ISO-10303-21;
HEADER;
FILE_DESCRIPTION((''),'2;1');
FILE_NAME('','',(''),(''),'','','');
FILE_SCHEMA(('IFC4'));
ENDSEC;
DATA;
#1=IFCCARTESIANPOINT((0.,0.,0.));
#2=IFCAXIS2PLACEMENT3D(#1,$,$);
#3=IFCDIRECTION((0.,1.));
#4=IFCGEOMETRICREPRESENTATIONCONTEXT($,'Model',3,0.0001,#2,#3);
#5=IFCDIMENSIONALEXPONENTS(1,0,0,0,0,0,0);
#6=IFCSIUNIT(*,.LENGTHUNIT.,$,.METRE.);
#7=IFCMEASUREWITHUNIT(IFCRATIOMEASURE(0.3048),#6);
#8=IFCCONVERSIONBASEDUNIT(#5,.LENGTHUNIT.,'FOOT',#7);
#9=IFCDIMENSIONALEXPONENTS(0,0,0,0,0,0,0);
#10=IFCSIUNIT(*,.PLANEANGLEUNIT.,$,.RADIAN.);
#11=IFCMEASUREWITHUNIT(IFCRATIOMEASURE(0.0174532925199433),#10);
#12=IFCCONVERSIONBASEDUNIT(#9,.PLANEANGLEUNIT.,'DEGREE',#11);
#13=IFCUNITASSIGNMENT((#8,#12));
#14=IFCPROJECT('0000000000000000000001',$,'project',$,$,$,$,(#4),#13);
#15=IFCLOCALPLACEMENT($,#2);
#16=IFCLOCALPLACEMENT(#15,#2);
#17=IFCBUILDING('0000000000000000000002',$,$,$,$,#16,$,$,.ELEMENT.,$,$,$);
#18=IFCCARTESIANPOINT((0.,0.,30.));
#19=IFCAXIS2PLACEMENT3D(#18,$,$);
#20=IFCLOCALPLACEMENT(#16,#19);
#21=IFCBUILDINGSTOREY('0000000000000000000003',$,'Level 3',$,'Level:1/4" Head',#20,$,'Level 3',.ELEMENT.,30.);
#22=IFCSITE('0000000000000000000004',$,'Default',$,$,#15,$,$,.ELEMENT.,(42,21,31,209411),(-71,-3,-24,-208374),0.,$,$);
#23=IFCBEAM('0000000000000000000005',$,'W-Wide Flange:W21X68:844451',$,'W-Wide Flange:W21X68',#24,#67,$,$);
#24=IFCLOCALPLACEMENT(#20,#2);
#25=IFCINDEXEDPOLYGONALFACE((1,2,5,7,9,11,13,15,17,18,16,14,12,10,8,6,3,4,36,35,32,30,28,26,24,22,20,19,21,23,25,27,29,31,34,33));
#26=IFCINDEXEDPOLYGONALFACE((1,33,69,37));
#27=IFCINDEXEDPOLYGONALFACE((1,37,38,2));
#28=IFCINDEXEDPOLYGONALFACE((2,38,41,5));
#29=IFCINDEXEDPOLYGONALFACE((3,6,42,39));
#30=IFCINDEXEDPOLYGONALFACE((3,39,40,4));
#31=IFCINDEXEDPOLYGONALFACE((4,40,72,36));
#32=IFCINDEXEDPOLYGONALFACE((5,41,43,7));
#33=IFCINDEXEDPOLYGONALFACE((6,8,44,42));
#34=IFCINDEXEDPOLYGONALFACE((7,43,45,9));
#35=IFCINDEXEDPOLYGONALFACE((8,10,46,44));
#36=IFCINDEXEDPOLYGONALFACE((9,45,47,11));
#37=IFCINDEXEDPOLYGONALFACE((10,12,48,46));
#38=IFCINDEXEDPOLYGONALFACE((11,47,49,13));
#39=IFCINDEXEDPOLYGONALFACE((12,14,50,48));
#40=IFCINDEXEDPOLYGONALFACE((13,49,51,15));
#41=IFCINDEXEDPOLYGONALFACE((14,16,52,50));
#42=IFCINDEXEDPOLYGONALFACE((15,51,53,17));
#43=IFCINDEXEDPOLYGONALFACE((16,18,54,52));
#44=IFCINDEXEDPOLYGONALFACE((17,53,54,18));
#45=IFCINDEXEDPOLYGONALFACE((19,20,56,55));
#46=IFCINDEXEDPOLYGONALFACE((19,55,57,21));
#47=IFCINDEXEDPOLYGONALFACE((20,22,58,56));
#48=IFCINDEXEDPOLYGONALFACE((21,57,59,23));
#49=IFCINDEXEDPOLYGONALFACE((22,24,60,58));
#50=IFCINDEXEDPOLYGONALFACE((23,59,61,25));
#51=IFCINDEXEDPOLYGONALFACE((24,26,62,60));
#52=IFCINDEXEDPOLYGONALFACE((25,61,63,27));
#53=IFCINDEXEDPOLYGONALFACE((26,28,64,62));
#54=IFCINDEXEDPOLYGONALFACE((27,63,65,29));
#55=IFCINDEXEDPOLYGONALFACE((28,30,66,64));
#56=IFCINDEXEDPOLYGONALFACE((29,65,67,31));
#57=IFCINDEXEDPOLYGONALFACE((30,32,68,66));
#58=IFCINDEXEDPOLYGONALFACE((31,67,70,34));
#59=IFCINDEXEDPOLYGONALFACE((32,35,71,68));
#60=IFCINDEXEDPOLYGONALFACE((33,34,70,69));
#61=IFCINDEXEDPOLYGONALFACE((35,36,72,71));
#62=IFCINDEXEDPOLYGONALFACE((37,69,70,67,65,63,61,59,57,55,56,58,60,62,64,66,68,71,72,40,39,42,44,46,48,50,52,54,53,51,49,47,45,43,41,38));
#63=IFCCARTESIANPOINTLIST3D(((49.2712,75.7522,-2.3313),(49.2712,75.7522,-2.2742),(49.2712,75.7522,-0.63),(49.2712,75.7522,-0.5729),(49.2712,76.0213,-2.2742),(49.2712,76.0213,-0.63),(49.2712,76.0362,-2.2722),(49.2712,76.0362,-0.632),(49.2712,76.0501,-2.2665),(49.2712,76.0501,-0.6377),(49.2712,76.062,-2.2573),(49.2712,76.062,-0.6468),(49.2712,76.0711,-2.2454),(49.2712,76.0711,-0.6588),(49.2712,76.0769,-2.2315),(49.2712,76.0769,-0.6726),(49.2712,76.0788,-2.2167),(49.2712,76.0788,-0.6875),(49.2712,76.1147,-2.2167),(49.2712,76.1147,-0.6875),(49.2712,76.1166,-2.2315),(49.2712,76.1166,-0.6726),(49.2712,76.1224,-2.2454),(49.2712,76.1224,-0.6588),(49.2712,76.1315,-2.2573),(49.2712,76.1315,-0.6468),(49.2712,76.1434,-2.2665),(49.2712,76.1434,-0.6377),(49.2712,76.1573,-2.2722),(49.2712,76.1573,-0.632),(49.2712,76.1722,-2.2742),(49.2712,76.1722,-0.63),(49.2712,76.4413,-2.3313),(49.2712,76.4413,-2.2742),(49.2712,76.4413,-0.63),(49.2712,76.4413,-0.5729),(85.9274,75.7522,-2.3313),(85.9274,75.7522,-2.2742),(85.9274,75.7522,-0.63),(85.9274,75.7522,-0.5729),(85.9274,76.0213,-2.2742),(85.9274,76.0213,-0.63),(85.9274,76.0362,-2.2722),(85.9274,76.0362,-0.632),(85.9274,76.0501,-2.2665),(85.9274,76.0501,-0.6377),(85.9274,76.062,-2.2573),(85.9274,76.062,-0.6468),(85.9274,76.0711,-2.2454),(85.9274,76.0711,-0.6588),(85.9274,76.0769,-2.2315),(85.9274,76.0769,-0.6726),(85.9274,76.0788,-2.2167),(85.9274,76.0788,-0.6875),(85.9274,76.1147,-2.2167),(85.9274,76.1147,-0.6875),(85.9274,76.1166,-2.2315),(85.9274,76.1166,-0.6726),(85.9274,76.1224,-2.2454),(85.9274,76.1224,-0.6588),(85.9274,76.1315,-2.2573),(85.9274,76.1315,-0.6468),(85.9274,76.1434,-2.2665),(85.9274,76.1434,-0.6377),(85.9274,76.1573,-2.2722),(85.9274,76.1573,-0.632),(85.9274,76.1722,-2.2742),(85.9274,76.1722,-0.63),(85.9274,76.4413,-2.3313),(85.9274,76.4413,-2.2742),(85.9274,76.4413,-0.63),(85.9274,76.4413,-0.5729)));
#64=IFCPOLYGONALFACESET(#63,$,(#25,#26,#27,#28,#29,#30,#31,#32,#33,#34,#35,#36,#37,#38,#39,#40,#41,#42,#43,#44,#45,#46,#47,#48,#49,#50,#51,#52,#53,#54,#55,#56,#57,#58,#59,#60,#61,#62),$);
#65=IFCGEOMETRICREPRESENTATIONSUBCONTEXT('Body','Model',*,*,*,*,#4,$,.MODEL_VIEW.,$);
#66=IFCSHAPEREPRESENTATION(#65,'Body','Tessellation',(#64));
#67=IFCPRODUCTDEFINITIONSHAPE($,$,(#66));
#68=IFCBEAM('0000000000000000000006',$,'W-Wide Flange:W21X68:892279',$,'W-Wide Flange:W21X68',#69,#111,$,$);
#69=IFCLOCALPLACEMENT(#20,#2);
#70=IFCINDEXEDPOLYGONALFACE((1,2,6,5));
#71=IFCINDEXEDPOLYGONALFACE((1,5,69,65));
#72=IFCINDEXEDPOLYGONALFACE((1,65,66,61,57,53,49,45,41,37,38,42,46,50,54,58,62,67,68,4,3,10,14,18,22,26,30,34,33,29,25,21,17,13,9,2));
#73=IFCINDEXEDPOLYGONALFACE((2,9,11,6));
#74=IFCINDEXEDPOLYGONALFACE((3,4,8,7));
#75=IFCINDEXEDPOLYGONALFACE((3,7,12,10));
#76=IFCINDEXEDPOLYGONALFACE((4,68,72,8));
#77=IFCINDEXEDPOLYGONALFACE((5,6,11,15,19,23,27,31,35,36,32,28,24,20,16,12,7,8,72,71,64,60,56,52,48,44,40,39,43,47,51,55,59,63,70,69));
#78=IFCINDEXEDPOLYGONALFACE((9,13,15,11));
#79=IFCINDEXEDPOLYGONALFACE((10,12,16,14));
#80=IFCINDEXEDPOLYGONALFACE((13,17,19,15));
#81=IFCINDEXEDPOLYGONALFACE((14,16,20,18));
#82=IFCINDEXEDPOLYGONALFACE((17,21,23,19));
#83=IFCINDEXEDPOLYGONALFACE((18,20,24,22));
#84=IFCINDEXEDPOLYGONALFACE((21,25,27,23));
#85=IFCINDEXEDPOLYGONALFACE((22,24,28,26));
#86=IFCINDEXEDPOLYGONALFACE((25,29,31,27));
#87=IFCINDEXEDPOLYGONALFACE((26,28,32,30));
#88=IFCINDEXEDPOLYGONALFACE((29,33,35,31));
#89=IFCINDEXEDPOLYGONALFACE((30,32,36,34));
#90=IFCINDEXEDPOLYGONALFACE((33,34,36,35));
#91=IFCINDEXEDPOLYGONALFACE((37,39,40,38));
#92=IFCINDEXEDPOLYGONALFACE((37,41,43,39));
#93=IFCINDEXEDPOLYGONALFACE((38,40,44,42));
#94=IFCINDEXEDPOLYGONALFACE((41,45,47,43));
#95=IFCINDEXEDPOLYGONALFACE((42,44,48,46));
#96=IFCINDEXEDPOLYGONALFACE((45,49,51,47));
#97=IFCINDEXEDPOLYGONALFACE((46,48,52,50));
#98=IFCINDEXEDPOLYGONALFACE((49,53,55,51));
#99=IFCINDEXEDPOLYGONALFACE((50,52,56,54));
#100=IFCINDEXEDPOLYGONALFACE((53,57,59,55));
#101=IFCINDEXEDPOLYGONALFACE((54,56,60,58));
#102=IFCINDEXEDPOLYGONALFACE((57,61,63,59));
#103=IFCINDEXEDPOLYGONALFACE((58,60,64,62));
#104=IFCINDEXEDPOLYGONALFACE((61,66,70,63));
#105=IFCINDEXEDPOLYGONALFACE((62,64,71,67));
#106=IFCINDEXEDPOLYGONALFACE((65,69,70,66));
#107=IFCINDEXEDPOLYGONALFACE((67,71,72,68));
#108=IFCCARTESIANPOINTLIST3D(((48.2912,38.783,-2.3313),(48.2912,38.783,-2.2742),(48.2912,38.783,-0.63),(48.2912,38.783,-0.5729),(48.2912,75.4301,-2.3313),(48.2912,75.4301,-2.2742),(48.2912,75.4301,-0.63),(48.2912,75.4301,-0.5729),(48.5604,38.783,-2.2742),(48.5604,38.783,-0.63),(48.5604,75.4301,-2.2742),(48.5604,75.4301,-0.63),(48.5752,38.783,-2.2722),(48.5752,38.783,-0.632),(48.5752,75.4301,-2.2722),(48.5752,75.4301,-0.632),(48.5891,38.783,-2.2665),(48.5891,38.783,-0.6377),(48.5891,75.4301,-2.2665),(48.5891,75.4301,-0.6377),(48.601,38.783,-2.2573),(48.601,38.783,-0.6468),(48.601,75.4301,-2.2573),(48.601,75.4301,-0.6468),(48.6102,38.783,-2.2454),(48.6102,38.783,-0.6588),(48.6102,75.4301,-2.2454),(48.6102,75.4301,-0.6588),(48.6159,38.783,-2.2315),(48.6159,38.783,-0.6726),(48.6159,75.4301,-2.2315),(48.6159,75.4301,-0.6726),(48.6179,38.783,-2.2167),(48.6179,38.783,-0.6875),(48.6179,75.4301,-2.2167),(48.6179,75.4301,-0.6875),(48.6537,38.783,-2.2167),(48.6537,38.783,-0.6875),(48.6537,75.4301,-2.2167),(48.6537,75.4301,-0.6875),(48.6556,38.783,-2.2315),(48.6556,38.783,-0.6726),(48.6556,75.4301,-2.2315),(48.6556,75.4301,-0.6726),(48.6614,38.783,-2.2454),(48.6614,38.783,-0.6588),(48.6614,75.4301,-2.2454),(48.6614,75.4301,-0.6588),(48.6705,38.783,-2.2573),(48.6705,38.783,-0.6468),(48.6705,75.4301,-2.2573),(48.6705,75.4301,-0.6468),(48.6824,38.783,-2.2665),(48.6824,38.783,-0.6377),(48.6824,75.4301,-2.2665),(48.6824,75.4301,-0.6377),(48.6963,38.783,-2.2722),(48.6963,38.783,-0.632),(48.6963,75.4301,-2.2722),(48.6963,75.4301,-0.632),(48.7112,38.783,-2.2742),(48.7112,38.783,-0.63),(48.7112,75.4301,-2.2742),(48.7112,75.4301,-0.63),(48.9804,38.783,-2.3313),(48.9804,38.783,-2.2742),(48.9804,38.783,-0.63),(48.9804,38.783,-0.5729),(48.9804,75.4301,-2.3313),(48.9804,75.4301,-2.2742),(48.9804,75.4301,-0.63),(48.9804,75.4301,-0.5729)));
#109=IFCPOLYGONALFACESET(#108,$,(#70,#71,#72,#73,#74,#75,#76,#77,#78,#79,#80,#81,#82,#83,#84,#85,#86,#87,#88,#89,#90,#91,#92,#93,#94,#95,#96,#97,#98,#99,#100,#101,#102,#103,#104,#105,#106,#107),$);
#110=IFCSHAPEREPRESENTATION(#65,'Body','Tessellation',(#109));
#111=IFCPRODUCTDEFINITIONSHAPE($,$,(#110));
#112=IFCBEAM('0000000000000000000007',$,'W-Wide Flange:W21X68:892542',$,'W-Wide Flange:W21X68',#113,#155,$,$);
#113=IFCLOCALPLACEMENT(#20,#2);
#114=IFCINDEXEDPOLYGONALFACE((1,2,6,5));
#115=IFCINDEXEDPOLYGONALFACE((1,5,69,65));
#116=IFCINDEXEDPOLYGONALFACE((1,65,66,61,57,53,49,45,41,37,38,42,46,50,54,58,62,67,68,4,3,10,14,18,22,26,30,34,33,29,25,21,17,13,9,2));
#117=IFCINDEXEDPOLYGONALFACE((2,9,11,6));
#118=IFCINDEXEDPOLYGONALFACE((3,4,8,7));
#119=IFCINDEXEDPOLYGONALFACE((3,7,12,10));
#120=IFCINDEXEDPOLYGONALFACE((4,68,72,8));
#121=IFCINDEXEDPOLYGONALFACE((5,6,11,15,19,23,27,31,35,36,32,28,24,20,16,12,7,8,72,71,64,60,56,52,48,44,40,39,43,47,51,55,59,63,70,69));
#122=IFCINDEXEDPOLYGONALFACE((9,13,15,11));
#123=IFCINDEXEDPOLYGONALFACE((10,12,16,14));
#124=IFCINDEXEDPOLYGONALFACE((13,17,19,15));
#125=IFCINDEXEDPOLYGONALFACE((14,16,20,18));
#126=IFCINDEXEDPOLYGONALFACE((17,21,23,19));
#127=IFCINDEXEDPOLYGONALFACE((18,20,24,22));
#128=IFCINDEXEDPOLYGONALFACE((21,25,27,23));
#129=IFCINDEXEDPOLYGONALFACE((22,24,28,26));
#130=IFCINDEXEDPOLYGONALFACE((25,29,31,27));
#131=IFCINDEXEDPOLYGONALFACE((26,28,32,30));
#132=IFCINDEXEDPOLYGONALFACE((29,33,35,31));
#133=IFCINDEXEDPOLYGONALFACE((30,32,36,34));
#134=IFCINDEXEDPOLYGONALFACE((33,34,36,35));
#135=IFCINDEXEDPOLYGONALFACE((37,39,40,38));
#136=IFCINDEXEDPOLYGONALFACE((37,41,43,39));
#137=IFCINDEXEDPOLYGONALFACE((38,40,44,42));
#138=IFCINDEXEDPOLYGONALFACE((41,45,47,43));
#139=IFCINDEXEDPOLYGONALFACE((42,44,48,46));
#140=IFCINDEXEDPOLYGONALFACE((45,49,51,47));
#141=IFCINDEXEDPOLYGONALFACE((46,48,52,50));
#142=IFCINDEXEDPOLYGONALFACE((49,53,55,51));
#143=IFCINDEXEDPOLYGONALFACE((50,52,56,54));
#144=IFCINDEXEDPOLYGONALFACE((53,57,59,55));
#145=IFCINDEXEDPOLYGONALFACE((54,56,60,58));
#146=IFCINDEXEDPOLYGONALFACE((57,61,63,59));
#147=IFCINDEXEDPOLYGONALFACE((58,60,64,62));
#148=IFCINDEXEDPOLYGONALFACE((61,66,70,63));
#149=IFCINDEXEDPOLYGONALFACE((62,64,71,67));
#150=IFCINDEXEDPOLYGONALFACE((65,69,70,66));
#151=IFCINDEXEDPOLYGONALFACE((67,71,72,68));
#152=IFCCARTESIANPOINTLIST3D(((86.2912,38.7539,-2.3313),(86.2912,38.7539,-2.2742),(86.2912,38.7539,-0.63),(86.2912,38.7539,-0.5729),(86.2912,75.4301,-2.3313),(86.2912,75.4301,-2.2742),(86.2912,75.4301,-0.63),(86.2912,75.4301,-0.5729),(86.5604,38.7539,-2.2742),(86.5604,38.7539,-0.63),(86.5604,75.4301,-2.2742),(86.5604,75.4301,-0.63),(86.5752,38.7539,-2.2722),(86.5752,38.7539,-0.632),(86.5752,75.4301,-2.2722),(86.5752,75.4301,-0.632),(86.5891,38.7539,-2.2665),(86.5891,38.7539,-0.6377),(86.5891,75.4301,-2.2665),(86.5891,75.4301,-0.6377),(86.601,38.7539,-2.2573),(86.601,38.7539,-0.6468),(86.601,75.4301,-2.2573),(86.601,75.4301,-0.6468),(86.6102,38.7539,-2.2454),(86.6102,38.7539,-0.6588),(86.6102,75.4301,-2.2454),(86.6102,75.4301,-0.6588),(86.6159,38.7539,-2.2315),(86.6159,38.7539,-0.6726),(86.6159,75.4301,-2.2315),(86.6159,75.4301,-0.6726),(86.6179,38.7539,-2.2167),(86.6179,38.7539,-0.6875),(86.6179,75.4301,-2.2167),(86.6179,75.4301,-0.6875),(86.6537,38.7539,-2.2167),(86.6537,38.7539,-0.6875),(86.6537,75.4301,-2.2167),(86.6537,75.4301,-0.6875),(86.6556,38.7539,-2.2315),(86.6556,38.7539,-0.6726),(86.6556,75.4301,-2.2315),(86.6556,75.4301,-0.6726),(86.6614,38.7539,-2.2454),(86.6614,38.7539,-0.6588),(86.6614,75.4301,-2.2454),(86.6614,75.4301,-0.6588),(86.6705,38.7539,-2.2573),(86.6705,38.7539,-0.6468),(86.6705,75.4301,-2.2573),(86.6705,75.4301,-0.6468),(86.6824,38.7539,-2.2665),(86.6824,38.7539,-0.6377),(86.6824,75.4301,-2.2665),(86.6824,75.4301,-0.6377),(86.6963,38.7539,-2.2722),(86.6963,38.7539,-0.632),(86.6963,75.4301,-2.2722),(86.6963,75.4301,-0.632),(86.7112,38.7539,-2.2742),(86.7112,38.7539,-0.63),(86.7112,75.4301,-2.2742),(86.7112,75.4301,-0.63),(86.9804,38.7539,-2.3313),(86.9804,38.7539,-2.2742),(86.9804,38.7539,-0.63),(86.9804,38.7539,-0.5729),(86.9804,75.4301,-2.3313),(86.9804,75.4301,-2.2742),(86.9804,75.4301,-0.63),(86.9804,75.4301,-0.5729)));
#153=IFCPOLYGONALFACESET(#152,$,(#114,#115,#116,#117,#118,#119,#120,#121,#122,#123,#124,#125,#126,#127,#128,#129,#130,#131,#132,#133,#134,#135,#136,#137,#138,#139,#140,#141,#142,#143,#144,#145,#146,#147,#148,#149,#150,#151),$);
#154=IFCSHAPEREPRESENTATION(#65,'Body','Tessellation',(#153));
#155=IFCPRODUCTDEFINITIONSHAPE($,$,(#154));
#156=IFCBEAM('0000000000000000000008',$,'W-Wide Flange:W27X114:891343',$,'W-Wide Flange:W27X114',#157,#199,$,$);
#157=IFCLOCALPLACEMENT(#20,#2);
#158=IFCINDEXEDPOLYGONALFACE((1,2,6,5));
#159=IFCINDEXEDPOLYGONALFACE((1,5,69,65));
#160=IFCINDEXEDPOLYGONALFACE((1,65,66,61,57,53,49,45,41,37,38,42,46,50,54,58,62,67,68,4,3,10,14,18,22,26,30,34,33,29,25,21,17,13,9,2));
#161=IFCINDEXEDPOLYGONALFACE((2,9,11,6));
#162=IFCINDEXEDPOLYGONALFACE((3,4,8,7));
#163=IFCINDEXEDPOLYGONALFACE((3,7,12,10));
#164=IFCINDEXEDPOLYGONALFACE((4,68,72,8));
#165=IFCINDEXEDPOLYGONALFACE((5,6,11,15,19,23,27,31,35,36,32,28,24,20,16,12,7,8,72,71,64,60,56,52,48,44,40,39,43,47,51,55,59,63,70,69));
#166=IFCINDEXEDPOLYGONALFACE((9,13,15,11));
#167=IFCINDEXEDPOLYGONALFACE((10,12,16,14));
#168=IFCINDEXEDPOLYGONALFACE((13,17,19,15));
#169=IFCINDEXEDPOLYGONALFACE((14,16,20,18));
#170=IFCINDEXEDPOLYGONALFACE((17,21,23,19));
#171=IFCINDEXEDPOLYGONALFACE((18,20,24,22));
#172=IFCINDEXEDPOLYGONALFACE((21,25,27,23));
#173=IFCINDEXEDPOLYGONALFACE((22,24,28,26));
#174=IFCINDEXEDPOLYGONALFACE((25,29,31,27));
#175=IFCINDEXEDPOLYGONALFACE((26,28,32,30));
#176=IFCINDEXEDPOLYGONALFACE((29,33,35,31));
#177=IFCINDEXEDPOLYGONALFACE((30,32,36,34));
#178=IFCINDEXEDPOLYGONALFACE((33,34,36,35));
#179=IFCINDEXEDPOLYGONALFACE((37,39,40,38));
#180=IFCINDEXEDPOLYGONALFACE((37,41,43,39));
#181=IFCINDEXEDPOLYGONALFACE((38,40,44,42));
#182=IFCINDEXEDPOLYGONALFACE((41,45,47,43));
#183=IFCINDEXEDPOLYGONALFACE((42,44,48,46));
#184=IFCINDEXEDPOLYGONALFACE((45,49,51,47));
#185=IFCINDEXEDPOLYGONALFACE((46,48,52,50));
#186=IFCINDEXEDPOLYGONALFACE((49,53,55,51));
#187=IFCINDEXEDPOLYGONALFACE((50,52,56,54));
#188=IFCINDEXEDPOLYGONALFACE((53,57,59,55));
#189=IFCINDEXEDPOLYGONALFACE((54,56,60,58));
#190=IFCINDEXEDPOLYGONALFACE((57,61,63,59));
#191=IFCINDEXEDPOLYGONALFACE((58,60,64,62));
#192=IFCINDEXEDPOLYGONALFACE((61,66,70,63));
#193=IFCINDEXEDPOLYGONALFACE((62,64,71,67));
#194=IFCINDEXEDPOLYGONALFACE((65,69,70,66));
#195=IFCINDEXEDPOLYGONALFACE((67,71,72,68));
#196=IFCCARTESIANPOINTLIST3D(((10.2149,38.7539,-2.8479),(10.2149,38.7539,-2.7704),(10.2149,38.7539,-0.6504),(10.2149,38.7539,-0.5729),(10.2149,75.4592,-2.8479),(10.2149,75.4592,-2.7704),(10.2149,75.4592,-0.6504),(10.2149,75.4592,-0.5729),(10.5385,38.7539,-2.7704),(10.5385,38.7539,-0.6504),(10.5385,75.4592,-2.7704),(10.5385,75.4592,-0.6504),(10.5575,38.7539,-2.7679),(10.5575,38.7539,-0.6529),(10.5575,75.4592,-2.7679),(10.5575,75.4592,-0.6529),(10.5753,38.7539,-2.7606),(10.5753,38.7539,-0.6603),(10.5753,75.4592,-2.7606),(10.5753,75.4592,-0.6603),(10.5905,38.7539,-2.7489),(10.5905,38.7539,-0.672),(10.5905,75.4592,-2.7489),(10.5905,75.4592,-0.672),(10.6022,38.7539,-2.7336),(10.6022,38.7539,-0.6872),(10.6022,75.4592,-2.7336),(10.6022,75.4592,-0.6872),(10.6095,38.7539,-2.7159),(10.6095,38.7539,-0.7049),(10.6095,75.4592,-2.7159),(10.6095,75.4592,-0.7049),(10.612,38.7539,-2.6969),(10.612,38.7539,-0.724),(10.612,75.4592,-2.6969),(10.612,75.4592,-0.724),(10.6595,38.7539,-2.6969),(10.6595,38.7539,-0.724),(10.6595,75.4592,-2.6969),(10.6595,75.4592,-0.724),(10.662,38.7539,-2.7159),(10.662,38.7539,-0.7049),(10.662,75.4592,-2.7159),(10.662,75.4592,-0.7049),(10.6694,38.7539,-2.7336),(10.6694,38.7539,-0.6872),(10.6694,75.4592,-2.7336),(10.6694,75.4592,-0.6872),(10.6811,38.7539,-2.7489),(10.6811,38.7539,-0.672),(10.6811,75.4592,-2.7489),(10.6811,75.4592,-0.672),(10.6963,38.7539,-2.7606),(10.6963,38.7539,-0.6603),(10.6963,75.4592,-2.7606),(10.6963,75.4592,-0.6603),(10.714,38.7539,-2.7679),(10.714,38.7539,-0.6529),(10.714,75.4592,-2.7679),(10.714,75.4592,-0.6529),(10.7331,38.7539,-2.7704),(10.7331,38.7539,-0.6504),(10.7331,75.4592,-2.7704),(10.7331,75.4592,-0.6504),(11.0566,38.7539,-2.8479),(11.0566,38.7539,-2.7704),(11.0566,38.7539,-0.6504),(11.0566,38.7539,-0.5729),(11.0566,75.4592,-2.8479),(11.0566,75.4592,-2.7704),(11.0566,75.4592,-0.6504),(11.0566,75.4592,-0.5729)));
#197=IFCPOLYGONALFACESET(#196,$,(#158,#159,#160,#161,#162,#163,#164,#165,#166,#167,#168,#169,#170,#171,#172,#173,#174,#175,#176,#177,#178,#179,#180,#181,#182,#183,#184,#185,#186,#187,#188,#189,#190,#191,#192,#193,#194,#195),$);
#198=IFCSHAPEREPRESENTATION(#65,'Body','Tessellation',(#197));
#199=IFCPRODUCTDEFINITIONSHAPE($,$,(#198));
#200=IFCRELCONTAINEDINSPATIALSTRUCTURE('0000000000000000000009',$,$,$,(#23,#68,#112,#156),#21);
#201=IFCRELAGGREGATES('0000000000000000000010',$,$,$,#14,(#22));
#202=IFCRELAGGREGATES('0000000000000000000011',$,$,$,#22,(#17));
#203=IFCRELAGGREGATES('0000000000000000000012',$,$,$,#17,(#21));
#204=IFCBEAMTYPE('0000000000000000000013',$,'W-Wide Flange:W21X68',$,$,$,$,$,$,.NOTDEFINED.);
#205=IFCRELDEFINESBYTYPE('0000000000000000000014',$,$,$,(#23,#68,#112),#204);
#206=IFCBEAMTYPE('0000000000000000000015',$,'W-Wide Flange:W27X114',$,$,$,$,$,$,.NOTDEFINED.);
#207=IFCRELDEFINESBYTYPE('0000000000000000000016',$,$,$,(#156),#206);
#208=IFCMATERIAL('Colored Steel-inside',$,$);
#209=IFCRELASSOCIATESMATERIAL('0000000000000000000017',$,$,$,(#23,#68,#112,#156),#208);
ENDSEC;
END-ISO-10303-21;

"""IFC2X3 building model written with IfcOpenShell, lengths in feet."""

from ifc_helpers import new_model, entity, si_unit, converted_unit, direction, frame, frame_2d, origin, place, context, subcontext, project, spatial, i_section, extrude, material, type_object, element, save


model = new_model("IFC2X3")

# Units and contexts
model_context = context("Model", 3, precision=0.0001, world=origin(), true_north=direction((0.0, 1.0)))
body_context = subcontext(model_context, "Body", "Model", "MODEL_VIEW")
ifc_project = project(units=[converted_unit("LENGTHUNIT", "FOOT", entity("IfcRatioMeasure", 0.3048), si_unit("LENGTHUNIT", "METRE"), dimensions=[1, 0, 0, 0, 0, 0, 0]), converted_unit("PLANEANGLEUNIT", "DEGREE", entity("IfcRatioMeasure", 0.0174532925199433), si_unit("PLANEANGLEUNIT", "RADIAN"), dimensions=[0, 0, 0, 0, 0, 0, 0])], contexts=[model_context])

# Site, building, storey
site_placement = place(None, origin())
site = spatial("IfcSite", under=ifc_project, at=site_placement, Name="Default", CompositionType="ELEMENT", RefLatitude=(42, 21, 31, 209411), RefLongitude=(-71, -3, -24, -208374), RefElevation=0.0)
building_placement = place(site_placement, origin())
building = spatial("IfcBuilding", under=site, at=building_placement, CompositionType="ELEMENT")
storey_placement = place(building_placement, frame((0.0, 0.0, 30.0)))
storey = spatial("IfcBuildingStorey", under=building, at=storey_placement, Name="Level 3", ObjectType="Level:1/4\" Head", LongName="Level 3", CompositionType="ELEMENT", Elevation=30.0)

# Beams
ifc_material_1 = material(Name="Colored Steel-inside")
beam_type_1 = type_object("IfcBeamType", Name="W-Wide Flange:W21X68", PredefinedType="NOTDEFINED")
beam_1_placement = place(storey_placement, frame((86.6554, 76.0968, 0.0), z_axis=(0.0, 0.0, 1.0), x_axis=(-1.0, 0.0, 0.0)))
element("IfcBeam", 1, at=beam_1_placement, inside=storey, type_object=beam_type_1, material=ifc_material_1, Name="W-Wide Flange:W21X68:844451", ObjectType="W-Wide Flange:W21X68", context=body_context, shape_type="SweptSolid", body=[
    extrude(i_section(OverallWidth=0.6892, OverallDepth=1.7583, WebThickness=0.0358, FlangeThickness=0.0571, FilletRadius=0.0575, at=frame_2d((0.0, 0.0), x_axis=(0.0, 1.0))), frame((0.7279, 0.0, -1.4521), z_axis=(1.0, 0.0, 0.0), x_axis=(0.0, 0.0, -1.0)), (0.0, 0.0, 1.0), 36.6562),
])
beam_2_placement = place(storey_placement, frame((48.6358, 76.0968, 0.0), z_axis=(0.0, 0.0, 1.0), x_axis=(0.0, -1.0, 0.0)))
element("IfcBeam", 2, at=beam_2_placement, inside=storey, type_object=beam_type_1, material=ifc_material_1, Name="W-Wide Flange:W21X68:892279", ObjectType="W-Wide Flange:W21X68", context=body_context, shape_type="SweptSolid", body=[
    extrude(i_section(OverallWidth=0.6892, OverallDepth=1.7583, WebThickness=0.0358, FlangeThickness=0.0571, FilletRadius=0.0575, at=frame_2d((0.0, 0.0), x_axis=(0.0, 1.0))), frame((0.6667, 0.0, -1.4521), z_axis=(1.0, 0.0, 0.0), x_axis=(0.0, 0.0, -1.0)), (0.0, 0.0, 1.0), 36.6471),
])
beam_3_placement = place(storey_placement, frame((86.6358, 76.0968, 0.0), z_axis=(0.0, 0.0, 1.0), x_axis=(0.0, -1.0, 0.0)))
element("IfcBeam", 3, at=beam_3_placement, inside=storey, type_object=beam_type_1, material=ifc_material_1, Name="W-Wide Flange:W21X68:892542", ObjectType="W-Wide Flange:W21X68", context=body_context, shape_type="SweptSolid", body=[
    extrude(i_section(OverallWidth=0.6892, OverallDepth=1.7583, WebThickness=0.0358, FlangeThickness=0.0571, FilletRadius=0.0575, at=frame_2d((0.0, 0.0), x_axis=(0.0, 1.0))), frame((0.6667, 0.0, -1.4521), z_axis=(1.0, 0.0, 0.0), x_axis=(0.0, 0.0, -1.0)), (0.0, 0.0, 1.0), 36.6762),
])
beam_type_2 = type_object("IfcBeamType", Name="W-Wide Flange:W27X114", PredefinedType="NOTDEFINED")
beam_4_placement = place(storey_placement, frame((10.6358, 76.0968, 0.0), z_axis=(0.0, 0.0, 1.0), x_axis=(0.0, -1.0, 0.0)))
element("IfcBeam", 4, at=beam_4_placement, inside=storey, type_object=beam_type_2, material=ifc_material_1, Name="W-Wide Flange:W27X114:891343", ObjectType="W-Wide Flange:W27X114", context=body_context, shape_type="SweptSolid", body=[
    extrude(i_section(OverallWidth=0.8417, OverallDepth=2.275, WebThickness=0.0475, FlangeThickness=0.0775, FilletRadius=0.0735, at=frame_2d((0.0, 0.0), x_axis=(0.0, 1.0))), frame((0.6376, 0.0, -1.7104), z_axis=(1.0, 0.0, 0.0), x_axis=(0.0, 0.0, -1.0)), (0.0, 0.0, 1.0), 36.7052),
])

save(model, "model.ifc")
